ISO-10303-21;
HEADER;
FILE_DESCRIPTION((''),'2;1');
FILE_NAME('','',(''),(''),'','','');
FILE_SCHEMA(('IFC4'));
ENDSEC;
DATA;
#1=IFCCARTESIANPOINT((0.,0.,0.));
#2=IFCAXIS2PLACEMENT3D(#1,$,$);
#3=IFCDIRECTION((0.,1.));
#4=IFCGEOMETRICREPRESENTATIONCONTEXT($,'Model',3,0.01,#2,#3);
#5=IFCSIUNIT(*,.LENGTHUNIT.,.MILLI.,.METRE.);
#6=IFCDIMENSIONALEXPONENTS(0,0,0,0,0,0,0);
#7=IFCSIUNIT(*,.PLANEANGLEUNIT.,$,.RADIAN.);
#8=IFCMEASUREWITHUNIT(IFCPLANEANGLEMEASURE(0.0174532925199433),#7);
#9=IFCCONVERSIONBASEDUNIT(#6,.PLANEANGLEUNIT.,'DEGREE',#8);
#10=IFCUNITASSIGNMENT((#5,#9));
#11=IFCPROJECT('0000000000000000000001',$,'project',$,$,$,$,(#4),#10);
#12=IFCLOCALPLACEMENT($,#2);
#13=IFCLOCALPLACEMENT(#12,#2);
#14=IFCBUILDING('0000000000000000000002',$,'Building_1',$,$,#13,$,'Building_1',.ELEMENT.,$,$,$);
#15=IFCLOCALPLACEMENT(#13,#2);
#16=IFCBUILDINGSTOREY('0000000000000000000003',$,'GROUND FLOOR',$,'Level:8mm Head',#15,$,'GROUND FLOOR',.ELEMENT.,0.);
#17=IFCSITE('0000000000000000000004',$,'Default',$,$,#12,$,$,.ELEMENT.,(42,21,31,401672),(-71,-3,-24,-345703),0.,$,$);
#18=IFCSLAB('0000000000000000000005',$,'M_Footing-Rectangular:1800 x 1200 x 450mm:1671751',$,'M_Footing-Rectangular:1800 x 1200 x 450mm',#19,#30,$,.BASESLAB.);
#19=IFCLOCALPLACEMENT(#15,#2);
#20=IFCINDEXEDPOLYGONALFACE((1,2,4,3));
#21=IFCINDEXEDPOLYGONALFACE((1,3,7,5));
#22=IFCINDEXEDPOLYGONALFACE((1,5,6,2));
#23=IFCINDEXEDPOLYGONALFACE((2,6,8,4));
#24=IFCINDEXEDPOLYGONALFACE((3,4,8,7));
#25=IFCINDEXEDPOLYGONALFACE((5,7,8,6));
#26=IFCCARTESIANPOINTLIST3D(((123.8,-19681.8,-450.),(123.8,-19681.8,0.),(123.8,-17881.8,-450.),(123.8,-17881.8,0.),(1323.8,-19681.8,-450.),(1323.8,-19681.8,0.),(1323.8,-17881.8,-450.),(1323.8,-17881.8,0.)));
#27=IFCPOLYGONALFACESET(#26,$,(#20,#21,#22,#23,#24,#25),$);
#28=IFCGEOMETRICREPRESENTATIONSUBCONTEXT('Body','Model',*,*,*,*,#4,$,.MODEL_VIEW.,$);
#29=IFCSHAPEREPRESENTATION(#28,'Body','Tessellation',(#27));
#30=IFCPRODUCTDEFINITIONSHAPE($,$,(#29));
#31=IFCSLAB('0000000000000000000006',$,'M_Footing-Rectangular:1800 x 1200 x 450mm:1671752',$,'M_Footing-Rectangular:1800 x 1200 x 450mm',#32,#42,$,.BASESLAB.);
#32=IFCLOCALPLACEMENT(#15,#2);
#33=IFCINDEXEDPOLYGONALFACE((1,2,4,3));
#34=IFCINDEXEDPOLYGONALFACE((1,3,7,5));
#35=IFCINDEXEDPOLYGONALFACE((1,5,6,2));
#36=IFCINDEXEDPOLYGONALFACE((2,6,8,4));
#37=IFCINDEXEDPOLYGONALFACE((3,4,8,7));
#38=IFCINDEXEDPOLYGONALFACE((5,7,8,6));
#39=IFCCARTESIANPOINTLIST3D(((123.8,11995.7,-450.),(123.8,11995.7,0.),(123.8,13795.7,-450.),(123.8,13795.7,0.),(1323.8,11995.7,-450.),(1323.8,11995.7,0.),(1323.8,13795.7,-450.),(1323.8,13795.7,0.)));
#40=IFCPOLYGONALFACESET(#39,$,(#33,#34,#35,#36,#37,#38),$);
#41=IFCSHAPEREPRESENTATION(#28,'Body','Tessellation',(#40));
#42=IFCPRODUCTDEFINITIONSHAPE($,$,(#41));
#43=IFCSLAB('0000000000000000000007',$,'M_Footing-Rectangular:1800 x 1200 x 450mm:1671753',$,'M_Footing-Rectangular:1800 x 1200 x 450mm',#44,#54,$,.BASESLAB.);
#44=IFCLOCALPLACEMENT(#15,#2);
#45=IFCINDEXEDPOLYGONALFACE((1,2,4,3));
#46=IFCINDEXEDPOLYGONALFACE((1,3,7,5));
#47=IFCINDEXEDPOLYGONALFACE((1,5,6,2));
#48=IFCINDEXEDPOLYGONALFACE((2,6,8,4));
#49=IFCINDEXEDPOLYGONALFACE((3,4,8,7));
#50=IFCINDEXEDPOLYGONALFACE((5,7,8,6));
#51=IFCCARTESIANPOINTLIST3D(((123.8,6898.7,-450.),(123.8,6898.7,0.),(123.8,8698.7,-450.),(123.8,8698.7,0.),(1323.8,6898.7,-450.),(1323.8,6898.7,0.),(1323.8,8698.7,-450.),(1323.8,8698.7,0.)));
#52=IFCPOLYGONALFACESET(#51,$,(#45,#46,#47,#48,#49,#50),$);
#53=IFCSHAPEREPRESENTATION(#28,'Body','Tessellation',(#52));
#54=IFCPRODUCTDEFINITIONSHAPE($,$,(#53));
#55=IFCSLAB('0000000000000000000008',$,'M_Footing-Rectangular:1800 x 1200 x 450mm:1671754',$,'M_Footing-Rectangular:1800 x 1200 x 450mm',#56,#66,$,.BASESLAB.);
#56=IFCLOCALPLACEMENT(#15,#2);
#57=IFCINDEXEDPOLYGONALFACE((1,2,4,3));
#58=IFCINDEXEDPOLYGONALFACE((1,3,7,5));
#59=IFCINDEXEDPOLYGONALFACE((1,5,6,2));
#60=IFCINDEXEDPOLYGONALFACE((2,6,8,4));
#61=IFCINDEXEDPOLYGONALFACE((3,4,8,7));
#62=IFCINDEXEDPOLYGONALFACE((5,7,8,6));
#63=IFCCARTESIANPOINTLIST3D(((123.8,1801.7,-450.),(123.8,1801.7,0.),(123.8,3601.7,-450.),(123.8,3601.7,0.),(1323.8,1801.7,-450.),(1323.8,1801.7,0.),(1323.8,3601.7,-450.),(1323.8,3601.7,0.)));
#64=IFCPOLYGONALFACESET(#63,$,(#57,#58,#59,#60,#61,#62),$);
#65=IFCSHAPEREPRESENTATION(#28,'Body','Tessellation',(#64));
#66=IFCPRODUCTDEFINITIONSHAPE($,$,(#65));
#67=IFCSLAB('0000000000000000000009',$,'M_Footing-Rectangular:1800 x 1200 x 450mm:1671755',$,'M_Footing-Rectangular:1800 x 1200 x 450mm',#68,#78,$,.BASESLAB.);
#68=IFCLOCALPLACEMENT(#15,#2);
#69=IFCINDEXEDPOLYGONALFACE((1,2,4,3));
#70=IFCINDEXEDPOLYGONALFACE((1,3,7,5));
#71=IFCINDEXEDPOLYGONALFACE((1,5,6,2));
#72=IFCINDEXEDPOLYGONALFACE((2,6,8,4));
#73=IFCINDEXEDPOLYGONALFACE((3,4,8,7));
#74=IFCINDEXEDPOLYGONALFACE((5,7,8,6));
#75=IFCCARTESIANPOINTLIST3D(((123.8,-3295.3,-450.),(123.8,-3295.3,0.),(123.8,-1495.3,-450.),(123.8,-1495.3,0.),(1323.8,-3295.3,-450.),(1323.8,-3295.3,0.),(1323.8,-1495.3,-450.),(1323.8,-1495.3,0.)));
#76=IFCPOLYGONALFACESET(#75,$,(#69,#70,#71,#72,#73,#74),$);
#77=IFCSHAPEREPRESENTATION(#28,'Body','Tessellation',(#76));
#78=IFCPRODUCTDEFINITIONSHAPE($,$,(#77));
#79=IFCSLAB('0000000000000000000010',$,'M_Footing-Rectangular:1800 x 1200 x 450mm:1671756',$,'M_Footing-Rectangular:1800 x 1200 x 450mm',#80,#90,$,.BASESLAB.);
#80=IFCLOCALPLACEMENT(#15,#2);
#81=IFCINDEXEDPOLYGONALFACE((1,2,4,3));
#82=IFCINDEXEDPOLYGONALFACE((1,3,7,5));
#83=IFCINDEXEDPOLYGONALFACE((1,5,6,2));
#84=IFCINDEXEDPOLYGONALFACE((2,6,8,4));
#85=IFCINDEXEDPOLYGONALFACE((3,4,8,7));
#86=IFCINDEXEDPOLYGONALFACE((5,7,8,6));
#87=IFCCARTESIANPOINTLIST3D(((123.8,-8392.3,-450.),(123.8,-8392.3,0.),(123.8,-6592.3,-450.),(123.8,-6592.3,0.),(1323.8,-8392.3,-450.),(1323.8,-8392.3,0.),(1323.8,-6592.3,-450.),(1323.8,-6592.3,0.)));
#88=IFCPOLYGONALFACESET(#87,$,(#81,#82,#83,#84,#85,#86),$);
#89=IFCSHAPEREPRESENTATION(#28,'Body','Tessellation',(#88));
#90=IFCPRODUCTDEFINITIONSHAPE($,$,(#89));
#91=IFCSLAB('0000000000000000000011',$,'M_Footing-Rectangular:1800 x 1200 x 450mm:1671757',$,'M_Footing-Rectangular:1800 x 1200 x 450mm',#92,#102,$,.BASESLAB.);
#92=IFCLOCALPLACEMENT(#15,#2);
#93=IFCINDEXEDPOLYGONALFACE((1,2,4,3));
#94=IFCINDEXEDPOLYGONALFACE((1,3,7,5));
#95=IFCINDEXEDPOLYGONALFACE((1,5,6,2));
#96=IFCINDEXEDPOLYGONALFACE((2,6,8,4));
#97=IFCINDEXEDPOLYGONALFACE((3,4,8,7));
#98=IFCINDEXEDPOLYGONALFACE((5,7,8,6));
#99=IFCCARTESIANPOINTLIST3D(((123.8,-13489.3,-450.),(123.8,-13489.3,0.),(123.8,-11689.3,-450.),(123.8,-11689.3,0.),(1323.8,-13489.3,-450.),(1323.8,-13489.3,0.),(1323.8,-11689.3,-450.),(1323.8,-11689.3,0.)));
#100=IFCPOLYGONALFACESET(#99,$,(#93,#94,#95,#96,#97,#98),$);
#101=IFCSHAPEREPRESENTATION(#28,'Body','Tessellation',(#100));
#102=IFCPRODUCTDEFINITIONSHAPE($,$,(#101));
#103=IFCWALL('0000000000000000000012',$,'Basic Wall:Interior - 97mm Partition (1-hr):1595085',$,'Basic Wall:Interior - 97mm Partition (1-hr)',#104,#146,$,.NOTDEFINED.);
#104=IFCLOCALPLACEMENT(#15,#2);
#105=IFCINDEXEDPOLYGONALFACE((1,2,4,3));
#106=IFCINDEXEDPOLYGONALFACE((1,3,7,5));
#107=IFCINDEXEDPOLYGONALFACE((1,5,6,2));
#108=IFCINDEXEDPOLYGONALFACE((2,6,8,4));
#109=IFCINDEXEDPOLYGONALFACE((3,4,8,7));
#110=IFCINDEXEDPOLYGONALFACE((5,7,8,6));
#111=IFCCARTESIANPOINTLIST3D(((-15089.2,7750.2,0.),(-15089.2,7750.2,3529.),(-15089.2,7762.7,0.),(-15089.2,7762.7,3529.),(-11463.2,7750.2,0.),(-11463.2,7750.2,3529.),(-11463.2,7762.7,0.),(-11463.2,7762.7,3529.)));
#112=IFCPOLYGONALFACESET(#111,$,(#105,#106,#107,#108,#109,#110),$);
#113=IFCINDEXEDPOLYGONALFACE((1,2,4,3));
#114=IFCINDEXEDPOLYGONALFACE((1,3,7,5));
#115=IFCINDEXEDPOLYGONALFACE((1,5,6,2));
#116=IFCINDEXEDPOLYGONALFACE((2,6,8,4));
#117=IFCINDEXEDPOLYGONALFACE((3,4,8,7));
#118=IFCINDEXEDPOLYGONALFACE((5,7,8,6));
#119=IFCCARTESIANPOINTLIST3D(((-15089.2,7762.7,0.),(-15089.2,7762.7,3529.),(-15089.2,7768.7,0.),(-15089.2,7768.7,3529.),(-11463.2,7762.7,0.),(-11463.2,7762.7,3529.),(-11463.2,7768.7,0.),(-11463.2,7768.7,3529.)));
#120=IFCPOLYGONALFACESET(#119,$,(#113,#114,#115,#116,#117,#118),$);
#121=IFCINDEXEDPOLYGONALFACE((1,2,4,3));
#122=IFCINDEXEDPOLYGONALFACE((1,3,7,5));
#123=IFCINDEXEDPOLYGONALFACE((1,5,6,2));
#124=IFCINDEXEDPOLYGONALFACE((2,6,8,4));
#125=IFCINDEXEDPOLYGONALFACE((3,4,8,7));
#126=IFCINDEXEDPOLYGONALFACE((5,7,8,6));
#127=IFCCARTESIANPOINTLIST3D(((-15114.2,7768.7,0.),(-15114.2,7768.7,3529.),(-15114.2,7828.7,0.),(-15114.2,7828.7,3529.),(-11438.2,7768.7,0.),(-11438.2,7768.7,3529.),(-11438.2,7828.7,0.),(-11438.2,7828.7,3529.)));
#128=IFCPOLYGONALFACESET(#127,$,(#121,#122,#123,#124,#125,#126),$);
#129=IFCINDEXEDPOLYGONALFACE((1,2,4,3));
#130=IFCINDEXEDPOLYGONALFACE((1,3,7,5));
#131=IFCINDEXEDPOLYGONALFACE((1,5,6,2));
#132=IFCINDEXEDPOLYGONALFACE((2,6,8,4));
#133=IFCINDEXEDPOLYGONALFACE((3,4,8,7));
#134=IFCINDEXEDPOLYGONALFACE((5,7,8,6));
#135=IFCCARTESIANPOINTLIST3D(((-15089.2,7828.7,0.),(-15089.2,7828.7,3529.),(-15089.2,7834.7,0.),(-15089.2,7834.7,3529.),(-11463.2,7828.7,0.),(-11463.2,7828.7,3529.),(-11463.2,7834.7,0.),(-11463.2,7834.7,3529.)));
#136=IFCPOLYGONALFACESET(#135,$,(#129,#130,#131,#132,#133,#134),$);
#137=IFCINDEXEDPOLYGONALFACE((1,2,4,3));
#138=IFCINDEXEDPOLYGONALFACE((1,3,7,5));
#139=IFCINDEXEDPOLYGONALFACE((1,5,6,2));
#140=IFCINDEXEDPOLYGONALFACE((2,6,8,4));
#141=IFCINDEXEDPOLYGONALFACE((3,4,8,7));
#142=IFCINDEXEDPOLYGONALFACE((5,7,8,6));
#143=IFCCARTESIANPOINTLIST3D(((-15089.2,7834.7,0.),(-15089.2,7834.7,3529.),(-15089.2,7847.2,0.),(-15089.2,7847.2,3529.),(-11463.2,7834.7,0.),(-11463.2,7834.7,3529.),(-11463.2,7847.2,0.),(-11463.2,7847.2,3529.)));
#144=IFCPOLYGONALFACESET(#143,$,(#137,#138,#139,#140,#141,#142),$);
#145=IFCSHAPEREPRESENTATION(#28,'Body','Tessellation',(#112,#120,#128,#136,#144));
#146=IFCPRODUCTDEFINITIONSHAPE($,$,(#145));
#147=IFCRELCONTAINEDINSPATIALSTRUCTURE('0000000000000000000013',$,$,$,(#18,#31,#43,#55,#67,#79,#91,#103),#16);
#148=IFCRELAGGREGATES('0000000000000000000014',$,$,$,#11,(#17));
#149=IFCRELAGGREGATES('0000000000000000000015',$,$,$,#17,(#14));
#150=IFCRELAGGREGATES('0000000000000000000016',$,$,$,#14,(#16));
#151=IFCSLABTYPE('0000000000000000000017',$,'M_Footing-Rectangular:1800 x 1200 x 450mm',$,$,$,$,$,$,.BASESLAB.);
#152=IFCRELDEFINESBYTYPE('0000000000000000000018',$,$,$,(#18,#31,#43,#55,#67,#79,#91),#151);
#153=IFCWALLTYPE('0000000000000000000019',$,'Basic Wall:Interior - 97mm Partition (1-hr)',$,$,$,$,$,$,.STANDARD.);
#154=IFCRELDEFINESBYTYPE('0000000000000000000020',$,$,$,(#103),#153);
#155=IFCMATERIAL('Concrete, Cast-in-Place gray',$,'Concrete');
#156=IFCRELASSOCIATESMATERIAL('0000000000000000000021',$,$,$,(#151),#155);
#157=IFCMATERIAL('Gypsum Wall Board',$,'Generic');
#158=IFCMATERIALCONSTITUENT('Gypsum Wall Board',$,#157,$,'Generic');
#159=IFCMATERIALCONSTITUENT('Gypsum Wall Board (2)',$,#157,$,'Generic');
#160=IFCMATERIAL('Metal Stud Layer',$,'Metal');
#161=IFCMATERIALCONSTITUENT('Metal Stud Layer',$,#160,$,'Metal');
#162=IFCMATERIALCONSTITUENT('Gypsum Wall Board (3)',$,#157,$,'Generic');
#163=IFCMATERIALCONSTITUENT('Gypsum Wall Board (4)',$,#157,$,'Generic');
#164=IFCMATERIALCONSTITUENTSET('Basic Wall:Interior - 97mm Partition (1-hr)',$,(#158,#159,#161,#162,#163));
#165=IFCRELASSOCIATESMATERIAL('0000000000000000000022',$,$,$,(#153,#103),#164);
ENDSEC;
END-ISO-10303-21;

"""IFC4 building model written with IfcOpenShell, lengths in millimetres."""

from ifc_helpers import new_model, entity, si_unit, converted_unit, direction, frame, origin, place, context, subcontext, project, spatial, indexed_curve, outline, extrude, material, constituent, constituent_set, type_object, element, save


model = new_model("IFC4")

# Units and contexts
model_context = context("Model", 3, precision=0.01, world=origin(), true_north=direction((0.0, 1.0)))
body_context = subcontext(model_context, "Body", "Model", "MODEL_VIEW")
ifc_project = project(units=[si_unit("LENGTHUNIT", "METRE", prefix="MILLI"), converted_unit("PLANEANGLEUNIT", "DEGREE", entity("IfcPlaneAngleMeasure", 0.0174532925199433), si_unit("PLANEANGLEUNIT", "RADIAN"), dimensions=[0, 0, 0, 0, 0, 0, 0])], contexts=[model_context])

# Site, building, storey
site_placement = place(None, origin())
site = spatial("IfcSite", under=ifc_project, at=site_placement, Name="Default", CompositionType="ELEMENT", RefLatitude=(42, 21, 31, 401672), RefLongitude=(-71, -3, -24, -345703), RefElevation=0.0)
building_placement = place(site_placement, origin())
building = spatial("IfcBuilding", under=site, at=building_placement, Name="Building_1", LongName="Building_1", CompositionType="ELEMENT")
storey_placement = place(building_placement, origin())
storey = spatial("IfcBuildingStorey", under=building, at=storey_placement, Name="GROUND FLOOR", ObjectType="Level:8mm Head", LongName="GROUND FLOOR", CompositionType="ELEMENT", Elevation=0.0)

# Slabs
ifc_material_1 = material(Name="Concrete, Cast-in-Place gray", Category="Concrete")
slab_type = type_object("IfcSlabType", Name="M_Footing-Rectangular:1800 x 1200 x 450mm", PredefinedType="BASESLAB", material=ifc_material_1)
slab_1_placement = place(storey_placement, origin())
element("IfcSlab", 1, at=slab_1_placement, inside=storey, type_object=slab_type, Name="M_Footing-Rectangular:1800 x 1200 x 450mm:1671751", ObjectType="M_Footing-Rectangular:1800 x 1200 x 450mm", PredefinedType="BASESLAB", context=body_context, shape_type="SweptSolid", body=[
    extrude(outline(indexed_curve([(-600.0, -900.0), (600.0, -900.0), (600.0, 900.0), (-600.0, 900.0), (-600.0, -900.0)], self_intersect=False)), frame((723.8, -18781.8, -450.0)), (0.0, 0.0, 1.0), 450.0),
])
slab_2_placement = place(storey_placement, origin())
element("IfcSlab", 2, at=slab_2_placement, inside=storey, type_object=slab_type, Name="M_Footing-Rectangular:1800 x 1200 x 450mm:1671752", ObjectType="M_Footing-Rectangular:1800 x 1200 x 450mm", PredefinedType="BASESLAB", context=body_context, shape_type="SweptSolid", body=[
    extrude(outline(indexed_curve([(-600.0, -900.0), (600.0, -900.0), (600.0, 900.0), (-600.0, 900.0), (-600.0, -900.0)], self_intersect=False)), frame((723.8, 12895.7, -450.0)), (0.0, 0.0, 1.0), 450.0),
])
slab_3_placement = place(storey_placement, origin())
element("IfcSlab", 3, at=slab_3_placement, inside=storey, type_object=slab_type, Name="M_Footing-Rectangular:1800 x 1200 x 450mm:1671753", ObjectType="M_Footing-Rectangular:1800 x 1200 x 450mm", PredefinedType="BASESLAB", context=body_context, shape_type="SweptSolid", body=[
    extrude(outline(indexed_curve([(-600.0, -900.0), (600.0, -900.0), (600.0, 900.0), (-600.0, 900.0), (-600.0, -900.0)], self_intersect=False)), frame((723.8, 7798.7, -450.0)), (0.0, 0.0, 1.0), 450.0),
])
slab_4_placement = place(storey_placement, origin())
element("IfcSlab", 4, at=slab_4_placement, inside=storey, type_object=slab_type, Name="M_Footing-Rectangular:1800 x 1200 x 450mm:1671754", ObjectType="M_Footing-Rectangular:1800 x 1200 x 450mm", PredefinedType="BASESLAB", context=body_context, shape_type="SweptSolid", body=[
    extrude(outline(indexed_curve([(-600.0, -900.0), (600.0, -900.0), (600.0, 900.0), (-600.0, 900.0), (-600.0, -900.0)], self_intersect=False)), frame((723.8, 2701.7, -450.0)), (0.0, 0.0, 1.0), 450.0),
])
slab_5_placement = place(storey_placement, origin())
element("IfcSlab", 5, at=slab_5_placement, inside=storey, type_object=slab_type, Name="M_Footing-Rectangular:1800 x 1200 x 450mm:1671755", ObjectType="M_Footing-Rectangular:1800 x 1200 x 450mm", PredefinedType="BASESLAB", context=body_context, shape_type="SweptSolid", body=[
    extrude(outline(indexed_curve([(-600.0, -900.0), (600.0, -900.0), (600.0, 900.0), (-600.0, 900.0), (-600.0, -900.0)], self_intersect=False)), frame((723.8, -2395.3, -450.0)), (0.0, 0.0, 1.0), 450.0),
])
slab_6_placement = place(storey_placement, origin())
element("IfcSlab", 6, at=slab_6_placement, inside=storey, type_object=slab_type, Name="M_Footing-Rectangular:1800 x 1200 x 450mm:1671756", ObjectType="M_Footing-Rectangular:1800 x 1200 x 450mm", PredefinedType="BASESLAB", context=body_context, shape_type="SweptSolid", body=[
    extrude(outline(indexed_curve([(-600.0, -900.0), (600.0, -900.0), (600.0, 900.0), (-600.0, 900.0), (-600.0, -900.0)], self_intersect=False)), frame((723.8, -7492.3, -450.0)), (0.0, 0.0, 1.0), 450.0),
])
slab_7_placement = place(storey_placement, origin())
element("IfcSlab", 7, at=slab_7_placement, inside=storey, type_object=slab_type, Name="M_Footing-Rectangular:1800 x 1200 x 450mm:1671757", ObjectType="M_Footing-Rectangular:1800 x 1200 x 450mm", PredefinedType="BASESLAB", context=body_context, shape_type="SweptSolid", body=[
    extrude(outline(indexed_curve([(-600.0, -900.0), (600.0, -900.0), (600.0, 900.0), (-600.0, 900.0), (-600.0, -900.0)], self_intersect=False)), frame((723.8, -12589.3, -450.0)), (0.0, 0.0, 1.0), 450.0),
])

# Wall
ifc_material_2 = material(Name="Gypsum Wall Board", Category="Generic")
ifc_constituent_1 = constituent(ifc_material_2, Name="Gypsum Wall Board", Category="Generic")
ifc_constituent_2 = constituent(ifc_material_2, Name="Gypsum Wall Board (2)", Category="Generic")
ifc_material_3 = material(Name="Metal Stud Layer", Category="Metal")
ifc_constituent_3 = constituent(ifc_material_3, Name="Metal Stud Layer", Category="Metal")
ifc_constituent_4 = constituent(ifc_material_2, Name="Gypsum Wall Board (3)", Category="Generic")
ifc_constituent_5 = constituent(ifc_material_2, Name="Gypsum Wall Board (4)", Category="Generic")
ifc_constituent_set_1 = constituent_set(constituents=[ifc_constituent_1, ifc_constituent_2, ifc_constituent_3, ifc_constituent_4, ifc_constituent_5], Name="Basic Wall:Interior - 97mm Partition (1-hr)")
wall_type_1 = type_object("IfcWallType", Name="Basic Wall:Interior - 97mm Partition (1-hr)", PredefinedType="STANDARD", material=ifc_constituent_set_1)
wall_1_placement = place(storey_placement, frame((-15089.2, 7798.7, 0.0)))
element("IfcWall", 8, at=wall_1_placement, inside=storey, type_object=wall_type_1, material=ifc_constituent_set_1, Name="Basic Wall:Interior - 97mm Partition (1-hr):1595085", ObjectType="Basic Wall:Interior - 97mm Partition (1-hr)", PredefinedType="NOTDEFINED", context=body_context, shape_type="SweptSolid", body=[
    extrude(outline(indexed_curve([(-6.3, -1813.0), (6.2, -1813.0), (6.3, 1813.0), (-6.2, 1813.0), (-6.3, -1813.0)], self_intersect=False)), frame((1813.0, -42.3, 0.0), z_axis=(0.0, 0.0, 1.0), x_axis=(0.0, 1.0, 0.0)), (0.0, 0.0, 1.0), 3529.0),
    extrude(outline(indexed_curve([(-1813.0, -3.0), (1813.0, -3.0), (1813.0, 3.0), (-1813.0, 3.0), (-1813.0, -3.0)], self_intersect=False)), frame((1813.0, -33.0, 0.0)), (0.0, 0.0, 1.0), 3529.0),
    extrude(outline(indexed_curve([(-1838.0, -30.0), (1838.0, -30.0), (1838.0, 30.0), (-1838.0, 30.0), (-1838.0, -30.0)], self_intersect=False)), frame((1813.0, 0.0, 0.0)), (0.0, 0.0, 1.0), 3529.0),
    extrude(outline(indexed_curve([(-1813.0, -3.0), (1813.0, -3.0), (1813.0, 3.0), (-1813.0, 3.0), (-1813.0, -3.0)], self_intersect=False)), frame((1813.0, 33.0, 0.0)), (0.0, 0.0, 1.0), 3529.0),
    extrude(outline(indexed_curve([(-6.3, -1813.0), (6.2, -1813.0), (6.3, 1813.0), (-6.2, 1813.0), (-6.3, -1813.0)], self_intersect=False)), frame((1813.0, 42.3, 0.0), z_axis=(0.0, 0.0, 1.0), x_axis=(0.0, -1.0, 0.0)), (0.0, 0.0, 1.0), 3529.0),
])

save(model, "model.ifc")
